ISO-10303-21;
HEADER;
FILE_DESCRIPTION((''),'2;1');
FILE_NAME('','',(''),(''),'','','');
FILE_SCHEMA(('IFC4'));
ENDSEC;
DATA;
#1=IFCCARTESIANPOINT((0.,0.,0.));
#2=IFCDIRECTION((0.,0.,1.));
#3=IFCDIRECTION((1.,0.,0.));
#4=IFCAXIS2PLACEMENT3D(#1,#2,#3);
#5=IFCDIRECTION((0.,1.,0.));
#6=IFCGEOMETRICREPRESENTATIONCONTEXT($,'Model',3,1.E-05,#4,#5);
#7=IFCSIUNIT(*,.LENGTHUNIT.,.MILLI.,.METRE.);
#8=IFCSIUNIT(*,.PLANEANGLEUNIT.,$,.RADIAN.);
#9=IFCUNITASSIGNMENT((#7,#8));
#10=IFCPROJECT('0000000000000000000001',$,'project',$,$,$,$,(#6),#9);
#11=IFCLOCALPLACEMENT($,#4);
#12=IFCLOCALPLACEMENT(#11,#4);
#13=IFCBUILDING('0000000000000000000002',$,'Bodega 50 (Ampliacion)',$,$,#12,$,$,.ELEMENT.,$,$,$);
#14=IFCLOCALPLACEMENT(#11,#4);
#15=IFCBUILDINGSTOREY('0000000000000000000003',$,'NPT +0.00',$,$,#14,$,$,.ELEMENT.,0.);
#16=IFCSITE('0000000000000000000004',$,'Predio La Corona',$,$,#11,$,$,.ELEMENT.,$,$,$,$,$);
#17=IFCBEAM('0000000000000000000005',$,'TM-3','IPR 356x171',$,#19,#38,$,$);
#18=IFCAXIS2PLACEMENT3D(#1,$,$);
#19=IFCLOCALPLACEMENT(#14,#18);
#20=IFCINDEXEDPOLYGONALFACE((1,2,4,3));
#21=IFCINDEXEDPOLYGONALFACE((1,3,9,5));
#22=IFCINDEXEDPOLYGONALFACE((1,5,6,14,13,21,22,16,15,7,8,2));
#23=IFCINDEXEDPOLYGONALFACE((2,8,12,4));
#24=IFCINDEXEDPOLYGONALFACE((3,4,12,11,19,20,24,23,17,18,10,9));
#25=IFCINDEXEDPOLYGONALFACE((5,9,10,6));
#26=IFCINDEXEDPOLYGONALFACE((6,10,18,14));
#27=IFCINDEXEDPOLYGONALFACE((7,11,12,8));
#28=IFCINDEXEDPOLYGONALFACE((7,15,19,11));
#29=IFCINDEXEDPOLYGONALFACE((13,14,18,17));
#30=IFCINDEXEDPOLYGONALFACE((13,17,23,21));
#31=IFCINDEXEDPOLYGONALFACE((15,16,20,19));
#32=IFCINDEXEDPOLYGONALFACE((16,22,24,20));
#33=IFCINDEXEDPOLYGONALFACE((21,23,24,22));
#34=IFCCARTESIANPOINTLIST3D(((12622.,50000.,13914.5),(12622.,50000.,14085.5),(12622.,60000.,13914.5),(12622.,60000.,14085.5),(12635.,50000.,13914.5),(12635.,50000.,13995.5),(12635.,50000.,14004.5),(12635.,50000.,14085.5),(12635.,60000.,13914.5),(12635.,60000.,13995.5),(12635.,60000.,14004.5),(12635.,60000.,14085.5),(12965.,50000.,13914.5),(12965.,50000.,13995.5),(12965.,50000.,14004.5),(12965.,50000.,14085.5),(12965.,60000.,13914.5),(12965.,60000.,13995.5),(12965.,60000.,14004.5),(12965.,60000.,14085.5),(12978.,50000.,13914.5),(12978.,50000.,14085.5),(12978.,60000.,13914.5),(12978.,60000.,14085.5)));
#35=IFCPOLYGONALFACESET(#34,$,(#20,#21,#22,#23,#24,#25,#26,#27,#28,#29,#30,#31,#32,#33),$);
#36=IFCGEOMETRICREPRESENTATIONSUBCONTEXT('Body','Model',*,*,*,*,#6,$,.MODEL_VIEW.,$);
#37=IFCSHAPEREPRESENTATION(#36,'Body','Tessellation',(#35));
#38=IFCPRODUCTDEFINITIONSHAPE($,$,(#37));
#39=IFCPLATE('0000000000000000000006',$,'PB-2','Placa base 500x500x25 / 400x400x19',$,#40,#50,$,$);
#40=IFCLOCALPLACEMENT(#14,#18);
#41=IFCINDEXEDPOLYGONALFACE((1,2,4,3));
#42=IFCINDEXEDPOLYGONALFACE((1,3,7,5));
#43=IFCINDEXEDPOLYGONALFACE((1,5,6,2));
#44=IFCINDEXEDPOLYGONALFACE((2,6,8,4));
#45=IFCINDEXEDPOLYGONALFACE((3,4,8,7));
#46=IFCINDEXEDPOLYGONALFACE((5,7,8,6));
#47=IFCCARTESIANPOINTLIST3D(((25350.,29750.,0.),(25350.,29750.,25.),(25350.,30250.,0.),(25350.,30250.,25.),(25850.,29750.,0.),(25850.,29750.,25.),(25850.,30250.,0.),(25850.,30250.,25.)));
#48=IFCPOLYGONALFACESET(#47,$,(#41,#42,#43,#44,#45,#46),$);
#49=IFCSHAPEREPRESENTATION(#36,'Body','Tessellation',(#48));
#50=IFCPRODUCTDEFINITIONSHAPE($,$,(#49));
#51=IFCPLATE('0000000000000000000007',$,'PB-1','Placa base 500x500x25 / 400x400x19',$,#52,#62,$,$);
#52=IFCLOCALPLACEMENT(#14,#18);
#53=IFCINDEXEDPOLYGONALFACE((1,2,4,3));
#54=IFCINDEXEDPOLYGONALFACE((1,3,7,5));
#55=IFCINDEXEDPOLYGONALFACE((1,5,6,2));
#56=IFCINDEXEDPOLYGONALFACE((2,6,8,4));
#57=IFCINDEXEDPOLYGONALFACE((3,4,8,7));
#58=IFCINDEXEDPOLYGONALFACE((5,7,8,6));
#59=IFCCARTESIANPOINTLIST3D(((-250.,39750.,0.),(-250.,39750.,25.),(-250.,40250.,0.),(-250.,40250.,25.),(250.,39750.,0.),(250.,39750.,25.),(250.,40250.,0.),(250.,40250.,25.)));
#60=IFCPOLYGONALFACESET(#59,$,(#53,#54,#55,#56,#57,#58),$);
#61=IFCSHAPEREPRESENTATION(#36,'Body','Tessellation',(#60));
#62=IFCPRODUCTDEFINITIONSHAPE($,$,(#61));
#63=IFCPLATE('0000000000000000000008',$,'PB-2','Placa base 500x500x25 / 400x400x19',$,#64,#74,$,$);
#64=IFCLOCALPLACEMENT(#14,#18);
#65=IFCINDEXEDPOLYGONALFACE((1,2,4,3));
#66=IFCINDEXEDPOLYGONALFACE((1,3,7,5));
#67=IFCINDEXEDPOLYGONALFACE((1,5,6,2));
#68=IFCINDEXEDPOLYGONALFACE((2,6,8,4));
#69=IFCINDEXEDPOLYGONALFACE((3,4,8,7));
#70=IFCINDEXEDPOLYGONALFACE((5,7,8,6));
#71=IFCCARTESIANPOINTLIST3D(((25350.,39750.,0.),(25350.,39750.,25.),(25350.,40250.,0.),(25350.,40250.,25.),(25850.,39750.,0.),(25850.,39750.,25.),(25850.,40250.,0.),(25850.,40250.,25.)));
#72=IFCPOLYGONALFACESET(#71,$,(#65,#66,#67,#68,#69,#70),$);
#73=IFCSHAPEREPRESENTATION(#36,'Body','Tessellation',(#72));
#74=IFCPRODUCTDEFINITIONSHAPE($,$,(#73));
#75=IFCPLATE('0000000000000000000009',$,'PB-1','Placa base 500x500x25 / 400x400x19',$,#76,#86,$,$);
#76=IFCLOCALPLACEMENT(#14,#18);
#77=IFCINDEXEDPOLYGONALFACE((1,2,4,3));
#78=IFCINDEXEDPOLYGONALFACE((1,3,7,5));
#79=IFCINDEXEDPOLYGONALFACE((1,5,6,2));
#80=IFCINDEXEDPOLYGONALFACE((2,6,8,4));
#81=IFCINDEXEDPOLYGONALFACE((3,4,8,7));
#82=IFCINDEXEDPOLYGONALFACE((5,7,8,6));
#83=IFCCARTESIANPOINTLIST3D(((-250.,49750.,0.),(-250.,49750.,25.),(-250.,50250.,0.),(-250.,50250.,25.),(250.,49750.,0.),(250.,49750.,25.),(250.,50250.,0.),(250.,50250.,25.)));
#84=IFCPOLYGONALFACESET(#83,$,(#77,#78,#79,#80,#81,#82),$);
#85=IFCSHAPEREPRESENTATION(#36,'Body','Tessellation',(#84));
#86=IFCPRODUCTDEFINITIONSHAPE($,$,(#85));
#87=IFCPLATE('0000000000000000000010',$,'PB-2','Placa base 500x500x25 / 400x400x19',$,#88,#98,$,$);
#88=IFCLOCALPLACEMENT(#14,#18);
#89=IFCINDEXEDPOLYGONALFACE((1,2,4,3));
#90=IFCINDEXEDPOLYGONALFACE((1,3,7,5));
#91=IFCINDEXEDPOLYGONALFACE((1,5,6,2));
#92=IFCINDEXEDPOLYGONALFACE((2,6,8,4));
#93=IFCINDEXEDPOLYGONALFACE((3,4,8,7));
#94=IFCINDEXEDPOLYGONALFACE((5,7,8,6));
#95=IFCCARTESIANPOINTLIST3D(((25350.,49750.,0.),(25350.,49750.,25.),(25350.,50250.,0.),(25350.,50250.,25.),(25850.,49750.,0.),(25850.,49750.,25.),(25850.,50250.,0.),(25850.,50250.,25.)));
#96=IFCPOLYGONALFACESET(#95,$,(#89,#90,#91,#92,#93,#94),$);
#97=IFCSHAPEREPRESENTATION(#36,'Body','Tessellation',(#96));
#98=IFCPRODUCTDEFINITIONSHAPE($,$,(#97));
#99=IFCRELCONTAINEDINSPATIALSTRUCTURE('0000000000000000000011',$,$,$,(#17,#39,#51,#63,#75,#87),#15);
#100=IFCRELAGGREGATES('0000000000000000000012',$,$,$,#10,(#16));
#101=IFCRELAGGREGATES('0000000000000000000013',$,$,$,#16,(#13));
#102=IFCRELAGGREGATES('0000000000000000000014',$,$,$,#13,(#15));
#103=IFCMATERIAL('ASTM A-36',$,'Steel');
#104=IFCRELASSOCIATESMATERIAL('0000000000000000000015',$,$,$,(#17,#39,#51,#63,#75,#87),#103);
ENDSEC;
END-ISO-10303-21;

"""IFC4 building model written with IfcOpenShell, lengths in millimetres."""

from ifc_helpers import new_model, si_unit, direction, frame, origin_with_axes, origin_2d, place, context, subcontext, project, spatial, rectangle, i_section, extrude, material, element, save


model = new_model("IFC4")

# Units and contexts
model_context = context("Model", 3, precision=1e-05, world=origin_with_axes(), true_north=direction((0.0, 1.0, 0.0)))
body_context = subcontext(model_context, "Body", "Model", "MODEL_VIEW")
ifc_project = project(units=[si_unit("LENGTHUNIT", "METRE", prefix="MILLI"), si_unit("PLANEANGLEUNIT", "RADIAN")], contexts=[model_context])

# Site, building, storey
site_placement = place(None, origin_with_axes())
site = spatial("IfcSite", under=ifc_project, at=site_placement, Name="Predio La Corona", CompositionType="ELEMENT")
building_placement = place(site_placement, origin_with_axes())
building = spatial("IfcBuilding", under=site, at=building_placement, Name="Bodega 50 (Ampliacion)", CompositionType="ELEMENT")
storey_placement = place(site_placement, origin_with_axes())
storey = spatial("IfcBuildingStorey", under=building, at=storey_placement, Name="NPT +0.00", CompositionType="ELEMENT", Elevation=0.0)

# Shared definitions
ifc_material = material(Name="ASTM A-36", Category="Steel")

# Beam
for number, where, z_axis, x_axis, name in (
    (1, (12800.0, 50000.0, 14000.0), (0.0, 1.0, 0.0), (0.0, 0.0, 1.0), "TM-3"),
):
    element("IfcBeam", number, at=place(storey_placement, frame(where, z_axis=z_axis, x_axis=x_axis)), inside=storey, material=ifc_material, Name=name, Description="IPR 356x171", context=body_context, shape_type="SweptSolid", body=[
        extrude(i_section(OverallWidth=171.0, OverallDepth=356.0, WebThickness=9.0, FlangeThickness=13.0, at=origin_2d()), origin_with_axes(), (0.0, 0.0, 1.0), 10000.0),
    ])

# Plates
for number, where, z_axis, x_axis, name in (
    (2, (25600.0, 30000.0, 0.0), (0.0, 0.0, 1.0), (1.0, 0.0, 0.0), "PB-2"),
    (3, (0.0, 40000.0, 0.0), (0.0, 0.0, 1.0), (1.0, 0.0, 0.0), "PB-1"),
    (4, (25600.0, 40000.0, 0.0), (0.0, 0.0, 1.0), (1.0, 0.0, 0.0), "PB-2"),
    (5, (0.0, 50000.0, 0.0), (0.0, 0.0, 1.0), (1.0, 0.0, 0.0), "PB-1"),
    (6, (25600.0, 50000.0, 0.0), (0.0, 0.0, 1.0), (1.0, 0.0, 0.0), "PB-2"),
):
    element("IfcPlate", number, at=place(storey_placement, frame(where, z_axis=z_axis, x_axis=x_axis)), inside=storey, material=ifc_material, Name=name, Description="Placa base 500x500x25 / 400x400x19", context=body_context, shape_type="SweptSolid", body=[
        extrude(rectangle(XDim=500.0, YDim=500.0, at=origin_2d()), origin_with_axes(), (0.0, 0.0, 1.0), 25.0),
    ])

save(model, "model.ifc")
